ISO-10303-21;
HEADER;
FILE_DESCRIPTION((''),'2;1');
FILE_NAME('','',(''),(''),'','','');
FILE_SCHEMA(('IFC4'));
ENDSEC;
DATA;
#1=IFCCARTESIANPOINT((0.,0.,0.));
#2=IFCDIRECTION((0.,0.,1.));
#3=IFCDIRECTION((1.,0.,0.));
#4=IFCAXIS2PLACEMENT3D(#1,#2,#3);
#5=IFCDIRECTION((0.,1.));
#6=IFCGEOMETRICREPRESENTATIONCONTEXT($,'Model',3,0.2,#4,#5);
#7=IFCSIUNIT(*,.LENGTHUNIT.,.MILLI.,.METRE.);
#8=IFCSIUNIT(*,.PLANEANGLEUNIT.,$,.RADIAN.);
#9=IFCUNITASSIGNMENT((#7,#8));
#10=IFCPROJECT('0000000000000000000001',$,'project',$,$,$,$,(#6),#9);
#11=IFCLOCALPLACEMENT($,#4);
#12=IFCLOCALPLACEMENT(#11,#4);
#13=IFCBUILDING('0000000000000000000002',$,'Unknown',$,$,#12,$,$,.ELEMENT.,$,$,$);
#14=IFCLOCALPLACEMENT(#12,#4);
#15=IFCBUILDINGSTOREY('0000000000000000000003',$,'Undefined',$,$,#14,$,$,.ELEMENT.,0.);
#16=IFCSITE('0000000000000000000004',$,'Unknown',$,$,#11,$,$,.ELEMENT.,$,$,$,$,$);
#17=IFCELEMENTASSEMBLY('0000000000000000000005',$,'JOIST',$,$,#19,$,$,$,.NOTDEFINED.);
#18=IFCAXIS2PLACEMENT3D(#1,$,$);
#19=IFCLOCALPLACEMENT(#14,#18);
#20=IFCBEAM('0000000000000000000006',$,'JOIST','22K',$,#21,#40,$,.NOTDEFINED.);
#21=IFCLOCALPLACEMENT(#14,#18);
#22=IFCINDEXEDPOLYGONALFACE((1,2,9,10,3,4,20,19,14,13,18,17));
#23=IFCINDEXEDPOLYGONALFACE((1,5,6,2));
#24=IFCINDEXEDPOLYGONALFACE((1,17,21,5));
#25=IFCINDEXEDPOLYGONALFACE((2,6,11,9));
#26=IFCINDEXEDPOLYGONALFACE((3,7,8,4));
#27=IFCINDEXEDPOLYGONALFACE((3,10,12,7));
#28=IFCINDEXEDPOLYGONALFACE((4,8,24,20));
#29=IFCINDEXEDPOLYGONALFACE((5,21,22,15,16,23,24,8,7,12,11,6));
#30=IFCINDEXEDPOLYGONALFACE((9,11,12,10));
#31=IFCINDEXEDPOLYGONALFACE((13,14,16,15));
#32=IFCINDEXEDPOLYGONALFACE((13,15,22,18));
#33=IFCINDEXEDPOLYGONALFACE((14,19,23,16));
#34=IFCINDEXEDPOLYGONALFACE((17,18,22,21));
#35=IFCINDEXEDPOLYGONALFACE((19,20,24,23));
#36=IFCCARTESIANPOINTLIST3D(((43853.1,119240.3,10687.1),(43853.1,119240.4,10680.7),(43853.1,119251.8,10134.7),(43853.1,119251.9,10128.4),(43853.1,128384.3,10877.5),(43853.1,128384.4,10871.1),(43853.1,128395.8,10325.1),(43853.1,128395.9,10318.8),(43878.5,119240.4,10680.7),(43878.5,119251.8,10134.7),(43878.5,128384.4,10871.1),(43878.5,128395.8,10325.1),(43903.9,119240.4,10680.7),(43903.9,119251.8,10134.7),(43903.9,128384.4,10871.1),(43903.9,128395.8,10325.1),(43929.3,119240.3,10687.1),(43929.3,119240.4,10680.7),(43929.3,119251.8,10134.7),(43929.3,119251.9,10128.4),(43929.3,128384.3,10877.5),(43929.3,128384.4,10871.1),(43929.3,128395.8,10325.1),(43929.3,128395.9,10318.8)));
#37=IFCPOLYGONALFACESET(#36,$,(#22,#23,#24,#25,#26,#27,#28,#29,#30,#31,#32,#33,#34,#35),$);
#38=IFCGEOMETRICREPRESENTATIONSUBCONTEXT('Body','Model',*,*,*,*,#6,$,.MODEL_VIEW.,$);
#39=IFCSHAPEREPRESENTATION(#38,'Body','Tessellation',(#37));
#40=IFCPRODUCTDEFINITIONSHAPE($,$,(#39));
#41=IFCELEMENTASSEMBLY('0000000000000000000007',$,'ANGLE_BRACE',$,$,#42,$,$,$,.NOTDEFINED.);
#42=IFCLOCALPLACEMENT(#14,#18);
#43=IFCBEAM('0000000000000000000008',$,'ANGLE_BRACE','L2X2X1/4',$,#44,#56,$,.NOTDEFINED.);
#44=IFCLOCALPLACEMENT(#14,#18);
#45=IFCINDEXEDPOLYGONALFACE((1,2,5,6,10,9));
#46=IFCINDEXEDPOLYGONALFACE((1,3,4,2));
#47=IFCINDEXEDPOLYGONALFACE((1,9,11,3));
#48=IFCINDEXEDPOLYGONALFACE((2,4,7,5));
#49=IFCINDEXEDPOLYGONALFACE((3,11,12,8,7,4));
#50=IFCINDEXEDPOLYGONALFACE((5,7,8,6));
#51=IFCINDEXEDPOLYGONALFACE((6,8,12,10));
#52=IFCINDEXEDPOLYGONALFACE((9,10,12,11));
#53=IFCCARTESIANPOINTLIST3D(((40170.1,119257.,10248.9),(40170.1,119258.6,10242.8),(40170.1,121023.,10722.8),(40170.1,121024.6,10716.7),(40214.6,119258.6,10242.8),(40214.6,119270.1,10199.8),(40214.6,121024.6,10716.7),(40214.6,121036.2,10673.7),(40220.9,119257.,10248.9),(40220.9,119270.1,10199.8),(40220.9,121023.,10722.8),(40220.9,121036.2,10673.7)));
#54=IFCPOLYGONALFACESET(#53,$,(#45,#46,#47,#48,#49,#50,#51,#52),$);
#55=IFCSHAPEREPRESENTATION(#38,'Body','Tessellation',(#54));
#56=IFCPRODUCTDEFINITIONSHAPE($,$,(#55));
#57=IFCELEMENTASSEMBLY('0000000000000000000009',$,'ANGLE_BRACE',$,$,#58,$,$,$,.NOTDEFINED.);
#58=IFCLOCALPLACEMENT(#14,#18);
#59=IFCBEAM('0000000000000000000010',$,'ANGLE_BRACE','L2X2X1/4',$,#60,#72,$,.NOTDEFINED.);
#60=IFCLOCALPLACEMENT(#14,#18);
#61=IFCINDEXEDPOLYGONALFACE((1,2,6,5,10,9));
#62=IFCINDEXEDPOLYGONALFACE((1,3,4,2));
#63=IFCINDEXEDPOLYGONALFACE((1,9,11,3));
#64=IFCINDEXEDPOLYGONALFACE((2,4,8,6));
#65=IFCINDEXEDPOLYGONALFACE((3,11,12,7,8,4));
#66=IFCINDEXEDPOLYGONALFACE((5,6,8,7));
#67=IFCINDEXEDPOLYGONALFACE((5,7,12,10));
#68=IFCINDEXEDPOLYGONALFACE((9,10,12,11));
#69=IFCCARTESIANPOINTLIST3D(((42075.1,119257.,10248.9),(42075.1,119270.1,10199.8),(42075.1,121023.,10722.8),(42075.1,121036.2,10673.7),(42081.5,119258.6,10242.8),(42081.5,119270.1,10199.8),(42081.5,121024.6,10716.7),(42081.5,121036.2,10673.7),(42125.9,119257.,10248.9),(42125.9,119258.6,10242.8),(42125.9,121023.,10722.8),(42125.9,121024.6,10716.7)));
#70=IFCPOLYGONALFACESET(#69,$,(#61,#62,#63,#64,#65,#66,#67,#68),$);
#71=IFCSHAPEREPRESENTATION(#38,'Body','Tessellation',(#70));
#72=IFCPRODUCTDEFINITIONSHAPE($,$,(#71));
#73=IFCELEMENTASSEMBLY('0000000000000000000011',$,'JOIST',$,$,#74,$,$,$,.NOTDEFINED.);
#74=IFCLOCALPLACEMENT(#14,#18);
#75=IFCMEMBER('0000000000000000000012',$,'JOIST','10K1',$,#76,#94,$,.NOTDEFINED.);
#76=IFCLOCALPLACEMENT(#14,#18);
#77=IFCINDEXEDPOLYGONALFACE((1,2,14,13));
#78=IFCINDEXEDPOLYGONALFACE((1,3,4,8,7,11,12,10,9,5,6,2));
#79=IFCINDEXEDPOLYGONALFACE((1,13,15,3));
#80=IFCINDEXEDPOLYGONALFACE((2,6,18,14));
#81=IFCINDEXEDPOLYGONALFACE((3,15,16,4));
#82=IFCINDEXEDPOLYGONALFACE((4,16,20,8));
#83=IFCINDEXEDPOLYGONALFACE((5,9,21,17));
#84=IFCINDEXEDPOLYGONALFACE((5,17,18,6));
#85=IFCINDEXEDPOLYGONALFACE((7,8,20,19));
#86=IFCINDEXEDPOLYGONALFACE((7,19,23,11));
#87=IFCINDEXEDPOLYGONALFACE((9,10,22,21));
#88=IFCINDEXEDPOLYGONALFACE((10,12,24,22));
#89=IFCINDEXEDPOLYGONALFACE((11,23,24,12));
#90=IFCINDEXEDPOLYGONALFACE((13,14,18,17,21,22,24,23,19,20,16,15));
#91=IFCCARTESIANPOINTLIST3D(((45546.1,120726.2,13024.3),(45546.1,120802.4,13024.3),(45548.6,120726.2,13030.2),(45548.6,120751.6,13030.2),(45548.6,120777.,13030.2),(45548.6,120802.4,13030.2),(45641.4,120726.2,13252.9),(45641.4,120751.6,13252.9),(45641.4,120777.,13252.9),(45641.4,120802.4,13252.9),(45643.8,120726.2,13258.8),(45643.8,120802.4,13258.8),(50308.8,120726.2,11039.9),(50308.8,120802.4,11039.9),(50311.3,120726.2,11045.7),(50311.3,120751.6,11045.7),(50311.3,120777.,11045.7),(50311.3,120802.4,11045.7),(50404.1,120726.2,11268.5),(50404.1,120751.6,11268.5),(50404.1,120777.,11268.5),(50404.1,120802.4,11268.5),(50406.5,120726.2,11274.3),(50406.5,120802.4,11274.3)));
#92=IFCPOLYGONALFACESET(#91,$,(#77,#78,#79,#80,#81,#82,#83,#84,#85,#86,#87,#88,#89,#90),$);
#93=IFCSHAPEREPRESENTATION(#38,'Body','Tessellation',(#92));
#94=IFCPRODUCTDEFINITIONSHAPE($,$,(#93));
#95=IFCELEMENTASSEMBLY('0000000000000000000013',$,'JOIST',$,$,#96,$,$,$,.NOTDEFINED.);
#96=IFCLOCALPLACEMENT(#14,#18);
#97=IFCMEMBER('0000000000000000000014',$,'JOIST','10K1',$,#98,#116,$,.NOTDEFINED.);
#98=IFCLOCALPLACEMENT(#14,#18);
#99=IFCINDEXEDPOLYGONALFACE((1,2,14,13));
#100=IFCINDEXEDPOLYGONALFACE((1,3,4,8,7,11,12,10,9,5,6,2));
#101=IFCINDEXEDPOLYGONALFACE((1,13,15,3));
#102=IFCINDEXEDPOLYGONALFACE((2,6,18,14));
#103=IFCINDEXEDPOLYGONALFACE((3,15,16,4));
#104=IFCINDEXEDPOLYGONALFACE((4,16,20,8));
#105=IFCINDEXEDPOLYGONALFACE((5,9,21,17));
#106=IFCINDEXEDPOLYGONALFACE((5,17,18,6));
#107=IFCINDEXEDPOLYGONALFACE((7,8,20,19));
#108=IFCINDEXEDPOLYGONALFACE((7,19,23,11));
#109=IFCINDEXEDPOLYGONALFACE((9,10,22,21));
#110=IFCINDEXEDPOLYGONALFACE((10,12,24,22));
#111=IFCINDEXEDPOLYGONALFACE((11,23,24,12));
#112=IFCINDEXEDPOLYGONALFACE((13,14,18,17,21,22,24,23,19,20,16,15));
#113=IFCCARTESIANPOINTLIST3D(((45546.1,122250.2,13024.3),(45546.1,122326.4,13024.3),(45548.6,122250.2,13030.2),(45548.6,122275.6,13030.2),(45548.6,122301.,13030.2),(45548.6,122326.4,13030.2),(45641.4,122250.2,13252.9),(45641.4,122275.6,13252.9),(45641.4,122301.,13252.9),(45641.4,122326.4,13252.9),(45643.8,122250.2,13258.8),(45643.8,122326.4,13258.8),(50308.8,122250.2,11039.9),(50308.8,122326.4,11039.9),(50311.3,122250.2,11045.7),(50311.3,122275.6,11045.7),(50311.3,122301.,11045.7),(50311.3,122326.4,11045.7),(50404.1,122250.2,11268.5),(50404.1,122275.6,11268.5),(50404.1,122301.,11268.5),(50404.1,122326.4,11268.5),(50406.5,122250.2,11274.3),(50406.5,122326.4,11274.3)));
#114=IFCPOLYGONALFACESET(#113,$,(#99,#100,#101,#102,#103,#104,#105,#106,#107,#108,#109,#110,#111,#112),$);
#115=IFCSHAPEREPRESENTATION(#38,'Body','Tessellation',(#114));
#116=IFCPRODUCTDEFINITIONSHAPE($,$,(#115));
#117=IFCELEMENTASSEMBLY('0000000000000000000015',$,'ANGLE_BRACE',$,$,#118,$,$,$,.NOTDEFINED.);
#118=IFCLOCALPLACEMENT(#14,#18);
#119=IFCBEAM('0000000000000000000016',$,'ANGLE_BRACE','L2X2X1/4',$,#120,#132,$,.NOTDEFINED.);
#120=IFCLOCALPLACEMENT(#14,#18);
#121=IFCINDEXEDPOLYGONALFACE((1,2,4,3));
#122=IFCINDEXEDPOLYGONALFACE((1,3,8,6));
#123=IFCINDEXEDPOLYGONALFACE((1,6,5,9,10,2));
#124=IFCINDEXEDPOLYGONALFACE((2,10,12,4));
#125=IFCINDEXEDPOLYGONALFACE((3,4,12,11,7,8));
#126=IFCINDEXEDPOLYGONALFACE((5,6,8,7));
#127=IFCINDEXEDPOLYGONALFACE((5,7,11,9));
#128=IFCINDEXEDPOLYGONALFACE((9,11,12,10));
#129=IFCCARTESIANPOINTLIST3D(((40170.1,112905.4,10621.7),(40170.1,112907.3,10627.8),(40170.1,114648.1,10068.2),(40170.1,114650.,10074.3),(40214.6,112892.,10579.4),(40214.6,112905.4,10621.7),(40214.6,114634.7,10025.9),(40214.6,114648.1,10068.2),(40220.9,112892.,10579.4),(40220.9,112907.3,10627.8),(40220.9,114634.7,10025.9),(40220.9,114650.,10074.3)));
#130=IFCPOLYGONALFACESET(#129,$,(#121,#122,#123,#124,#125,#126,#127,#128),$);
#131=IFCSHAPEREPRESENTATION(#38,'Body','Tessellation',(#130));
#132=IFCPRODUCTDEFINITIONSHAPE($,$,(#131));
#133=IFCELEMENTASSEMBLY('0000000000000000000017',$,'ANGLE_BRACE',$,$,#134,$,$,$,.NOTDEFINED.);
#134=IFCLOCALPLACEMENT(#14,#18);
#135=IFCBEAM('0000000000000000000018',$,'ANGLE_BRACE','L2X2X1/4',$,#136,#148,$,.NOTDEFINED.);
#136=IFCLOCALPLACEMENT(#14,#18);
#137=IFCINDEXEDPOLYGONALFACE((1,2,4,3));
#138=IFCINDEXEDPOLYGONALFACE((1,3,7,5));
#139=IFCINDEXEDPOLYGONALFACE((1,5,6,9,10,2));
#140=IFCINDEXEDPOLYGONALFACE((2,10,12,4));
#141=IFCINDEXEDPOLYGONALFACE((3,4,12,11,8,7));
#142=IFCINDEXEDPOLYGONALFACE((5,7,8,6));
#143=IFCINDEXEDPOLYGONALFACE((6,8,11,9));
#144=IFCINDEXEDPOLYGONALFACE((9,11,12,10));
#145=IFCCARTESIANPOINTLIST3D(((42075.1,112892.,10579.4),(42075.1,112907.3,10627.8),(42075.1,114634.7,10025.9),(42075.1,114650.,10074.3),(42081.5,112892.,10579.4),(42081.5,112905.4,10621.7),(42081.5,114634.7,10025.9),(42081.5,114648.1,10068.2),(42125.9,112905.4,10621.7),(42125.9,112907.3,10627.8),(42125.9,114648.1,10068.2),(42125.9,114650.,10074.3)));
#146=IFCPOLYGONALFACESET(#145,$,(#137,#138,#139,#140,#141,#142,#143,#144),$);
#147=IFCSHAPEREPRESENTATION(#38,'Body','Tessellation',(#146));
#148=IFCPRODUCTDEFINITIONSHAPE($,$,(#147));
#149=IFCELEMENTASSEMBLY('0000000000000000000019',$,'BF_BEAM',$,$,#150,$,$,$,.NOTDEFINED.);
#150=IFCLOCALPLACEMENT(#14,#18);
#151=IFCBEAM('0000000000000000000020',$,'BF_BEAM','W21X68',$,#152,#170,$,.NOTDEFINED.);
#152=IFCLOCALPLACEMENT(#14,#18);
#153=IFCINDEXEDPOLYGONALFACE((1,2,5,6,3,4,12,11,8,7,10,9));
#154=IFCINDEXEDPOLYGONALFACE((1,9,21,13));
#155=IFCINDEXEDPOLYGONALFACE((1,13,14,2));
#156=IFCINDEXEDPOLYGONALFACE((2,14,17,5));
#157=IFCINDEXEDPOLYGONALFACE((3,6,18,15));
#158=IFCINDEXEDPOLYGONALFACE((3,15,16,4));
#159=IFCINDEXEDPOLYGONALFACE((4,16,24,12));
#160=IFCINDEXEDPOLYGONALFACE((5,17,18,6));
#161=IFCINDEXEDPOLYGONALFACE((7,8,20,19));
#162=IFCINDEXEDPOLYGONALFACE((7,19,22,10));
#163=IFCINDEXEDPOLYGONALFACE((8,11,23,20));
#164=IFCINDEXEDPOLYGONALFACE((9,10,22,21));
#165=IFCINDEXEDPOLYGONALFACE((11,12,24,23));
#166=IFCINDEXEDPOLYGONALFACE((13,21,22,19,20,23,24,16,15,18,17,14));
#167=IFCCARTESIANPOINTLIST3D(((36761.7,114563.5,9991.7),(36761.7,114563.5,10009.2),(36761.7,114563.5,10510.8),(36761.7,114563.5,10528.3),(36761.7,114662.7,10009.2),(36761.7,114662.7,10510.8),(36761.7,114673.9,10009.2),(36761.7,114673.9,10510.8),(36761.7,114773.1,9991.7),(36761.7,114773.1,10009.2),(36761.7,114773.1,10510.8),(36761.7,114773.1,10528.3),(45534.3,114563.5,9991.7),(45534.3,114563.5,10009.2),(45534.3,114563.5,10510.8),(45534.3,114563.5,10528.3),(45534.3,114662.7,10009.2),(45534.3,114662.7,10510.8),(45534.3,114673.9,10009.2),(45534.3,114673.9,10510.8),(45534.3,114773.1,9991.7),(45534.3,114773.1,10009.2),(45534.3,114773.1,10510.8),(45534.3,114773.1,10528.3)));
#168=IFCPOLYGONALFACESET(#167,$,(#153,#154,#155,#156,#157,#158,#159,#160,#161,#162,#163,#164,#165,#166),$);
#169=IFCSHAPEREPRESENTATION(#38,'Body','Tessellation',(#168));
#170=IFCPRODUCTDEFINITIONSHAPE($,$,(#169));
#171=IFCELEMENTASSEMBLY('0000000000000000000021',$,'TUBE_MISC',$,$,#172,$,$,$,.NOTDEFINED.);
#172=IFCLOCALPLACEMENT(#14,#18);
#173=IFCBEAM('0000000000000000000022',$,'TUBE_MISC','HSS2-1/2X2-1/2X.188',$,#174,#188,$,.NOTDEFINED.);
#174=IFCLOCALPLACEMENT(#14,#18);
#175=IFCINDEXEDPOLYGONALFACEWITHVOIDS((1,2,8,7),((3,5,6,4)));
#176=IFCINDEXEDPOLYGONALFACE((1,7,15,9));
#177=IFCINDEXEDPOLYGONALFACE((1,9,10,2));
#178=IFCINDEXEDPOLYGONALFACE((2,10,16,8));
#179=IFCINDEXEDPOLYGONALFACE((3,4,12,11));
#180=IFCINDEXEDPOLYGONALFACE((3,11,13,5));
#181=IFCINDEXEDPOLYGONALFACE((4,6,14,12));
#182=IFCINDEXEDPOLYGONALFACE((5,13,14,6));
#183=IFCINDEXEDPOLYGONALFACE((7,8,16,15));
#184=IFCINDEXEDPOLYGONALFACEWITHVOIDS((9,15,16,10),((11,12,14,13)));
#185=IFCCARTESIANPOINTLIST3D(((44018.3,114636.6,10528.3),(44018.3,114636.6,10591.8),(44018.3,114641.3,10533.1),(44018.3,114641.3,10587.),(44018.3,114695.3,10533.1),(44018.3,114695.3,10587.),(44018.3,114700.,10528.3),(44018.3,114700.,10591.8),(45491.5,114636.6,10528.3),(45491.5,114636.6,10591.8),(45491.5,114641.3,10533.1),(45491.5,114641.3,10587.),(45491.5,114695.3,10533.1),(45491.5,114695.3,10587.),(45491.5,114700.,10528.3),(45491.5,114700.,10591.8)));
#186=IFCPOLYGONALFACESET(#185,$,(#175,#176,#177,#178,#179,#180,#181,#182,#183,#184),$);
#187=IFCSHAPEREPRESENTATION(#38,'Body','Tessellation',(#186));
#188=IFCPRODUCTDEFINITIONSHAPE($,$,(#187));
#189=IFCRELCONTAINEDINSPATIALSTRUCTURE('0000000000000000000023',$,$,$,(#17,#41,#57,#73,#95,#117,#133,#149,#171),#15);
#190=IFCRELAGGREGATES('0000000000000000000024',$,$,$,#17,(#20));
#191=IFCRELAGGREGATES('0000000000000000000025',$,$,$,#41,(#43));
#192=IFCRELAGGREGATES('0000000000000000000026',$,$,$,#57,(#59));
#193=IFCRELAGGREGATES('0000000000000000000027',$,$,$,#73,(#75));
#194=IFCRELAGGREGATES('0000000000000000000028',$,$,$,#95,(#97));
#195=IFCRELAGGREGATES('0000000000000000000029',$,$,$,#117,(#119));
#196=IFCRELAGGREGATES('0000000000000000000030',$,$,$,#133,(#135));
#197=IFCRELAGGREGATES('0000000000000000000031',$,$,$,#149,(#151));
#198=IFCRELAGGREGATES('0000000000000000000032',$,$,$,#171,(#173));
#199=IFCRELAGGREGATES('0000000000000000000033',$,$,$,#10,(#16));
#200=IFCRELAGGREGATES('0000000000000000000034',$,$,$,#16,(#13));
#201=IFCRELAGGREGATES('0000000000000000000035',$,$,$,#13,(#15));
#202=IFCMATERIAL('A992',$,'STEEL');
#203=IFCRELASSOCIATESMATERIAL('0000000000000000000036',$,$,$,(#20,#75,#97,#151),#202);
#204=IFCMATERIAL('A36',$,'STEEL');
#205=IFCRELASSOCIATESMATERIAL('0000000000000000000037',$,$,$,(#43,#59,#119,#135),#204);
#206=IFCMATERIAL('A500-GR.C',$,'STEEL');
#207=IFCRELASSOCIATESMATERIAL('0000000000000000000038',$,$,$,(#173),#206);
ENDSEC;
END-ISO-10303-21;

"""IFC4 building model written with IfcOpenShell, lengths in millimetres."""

from ifc_helpers import new_model, si_unit, direction, frame, origin_with_axes, place, context, subcontext, project, spatial, line, indexed_curve, outline, extrude, material, element, aggregate, save


model = new_model("IFC4")

# Units and contexts
model_context = context("Model", 3, precision=0.2, world=origin_with_axes(), true_north=direction((0.0, 1.0)))
body_context = subcontext(model_context, "Body", "Model", "MODEL_VIEW")
ifc_project = project(units=[si_unit("LENGTHUNIT", "METRE", prefix="MILLI"), si_unit("PLANEANGLEUNIT", "RADIAN")], contexts=[model_context])

# Site, building, storey
site_placement = place(None, origin_with_axes())
site = spatial("IfcSite", under=ifc_project, at=site_placement, Name="Unknown", CompositionType="ELEMENT")
building_placement = place(site_placement, origin_with_axes())
building = spatial("IfcBuilding", under=site, at=building_placement, Name="Unknown", CompositionType="ELEMENT")
storey_placement = place(building_placement, origin_with_axes())
storey = spatial("IfcBuildingStorey", under=building, at=storey_placement, Name="Undefined", CompositionType="ELEMENT", Elevation=0.0)

# Element assemblies, beams
ifc_material_1 = material(Name="A992", Category="STEEL")
assembly_1_placement = place(storey_placement, frame((43891.2, 119246.1, 10407.7), z_axis=(1.0, 0.0, 0.0), x_axis=(0.0, 0.999783, 0.020819)))
assembly_1 = element("IfcElementAssembly", 1, at=assembly_1_placement, inside=storey, Name="JOIST", PredefinedType="NOTDEFINED")
beam_1_placement = place(assembly_1_placement, origin_with_axes())
beam_1 = element("IfcBeam", 2, at=beam_1_placement, material=ifc_material_1, Name="JOIST", Description="22K", PredefinedType="NOTDEFINED", context=body_context, shape_type="SolidModel", body=[
    extrude(outline(indexed_curve([(-38.1, -279.4), (38.1, -279.4), (38.1, -273.0), (12.7, -273.0), (12.7, 273.0), (38.1, 273.0), (38.1, 279.4), (-38.1, 279.4), (-38.1, 273.0), (-12.7, 273.0), (-12.7, -273.0), (-38.1, -273.0)], segments=[line(1, 2, 3, 4, 5, 6, 7, 8, 9, 10, 11, 12, 1)])), frame((0.0, 0.0, 0.0), z_axis=(-1.0, 0.0, 0.0), x_axis=(0.0, 0.0, 1.0)), (0.0, 0.0, -1.0), 9146.0),
])
aggregate(assembly_1, [beam_1])
assembly_2_placement = place(storey_placement, frame((40195.5, 119263.6, 10224.4), z_axis=(-1.0, 0.0, 0.0), x_axis=(0.0, 0.965831, 0.259174)))
assembly_2 = element("IfcElementAssembly", 3, at=assembly_2_placement, inside=storey, Name="ANGLE_BRACE", PredefinedType="NOTDEFINED")
ifc_material_2 = material(Name="A36", Category="STEEL")
beam_2_placement = place(assembly_2_placement, origin_with_axes())
beam_2 = element("IfcBeam", 4, at=beam_2_placement, material=ifc_material_2, Name="ANGLE_BRACE", Description="L2X2X1/4", PredefinedType="NOTDEFINED", context=body_context, shape_type="SolidModel", body=[
    extrude(outline(indexed_curve([(-25.4, -25.4), (25.4, -25.4), (25.4, -19.1), (-19.1, -19.1), (-19.1, 25.4), (-25.4, 25.4)], segments=[line(1, 2, 3, 4, 5, 6, 1)])), frame((0.0, 0.0, 0.0), z_axis=(-1.0, 0.0, 0.0), x_axis=(0.0, 0.0, 1.0)), (0.0, 0.0, -1.0), 1828.5),
])
aggregate(assembly_2, [beam_2])
assembly_3_placement = place(storey_placement, frame((42100.5, 119263.6, 10224.4), z_axis=(0.0, 0.259174, -0.965831), x_axis=(0.0, 0.965831, 0.259174)))
assembly_3 = element("IfcElementAssembly", 5, at=assembly_3_placement, inside=storey, Name="ANGLE_BRACE", PredefinedType="NOTDEFINED")
beam_3_placement = place(assembly_3_placement, origin_with_axes())
beam_3 = element("IfcBeam", 6, at=beam_3_placement, material=ifc_material_2, Name="ANGLE_BRACE", Description="L2X2X1/4", PredefinedType="NOTDEFINED", context=body_context, shape_type="SolidModel", body=[
    extrude(outline(indexed_curve([(-25.4, -25.4), (25.4, -25.4), (25.4, -19.1), (-19.1, -19.1), (-19.1, 25.4), (-25.4, 25.4)], segments=[line(1, 2, 3, 4, 5, 6, 1)])), frame((0.0, 0.0, 0.0), z_axis=(-1.0, 0.0, 0.0), x_axis=(0.0, 0.0, 1.0)), (0.0, 0.0, -1.0), 1828.5),
])
aggregate(assembly_3, [beam_3])

# Element assemblies, members
assembly_4_placement = place(storey_placement, frame((45595.0, 120764.3, 13141.6), z_axis=(0.0, -1.0, 0.0), x_axis=(0.923077, 0.000001, -0.384615)))
assembly_4 = element("IfcElementAssembly", 7, at=assembly_4_placement, inside=storey, Name="JOIST", PredefinedType="NOTDEFINED")
member_1_placement = place(assembly_4_placement, origin_with_axes())
member_1 = element("IfcMember", 8, at=member_1_placement, material=ifc_material_1, Name="JOIST", Description="10K1", PredefinedType="NOTDEFINED", context=body_context, shape_type="SolidModel", body=[
    extrude(outline(indexed_curve([(-38.1, -127.0), (38.1, -127.0), (38.1, -120.7), (12.7, -120.7), (12.7, 120.7), (38.1, 120.7), (38.1, 127.0), (-38.1, 127.0), (-38.1, 120.7), (-12.7, 120.7), (-12.7, -120.7), (-38.1, -120.7)], segments=[line(1, 2, 3, 4, 5, 6, 7, 8, 9, 10, 11, 12, 1)])), frame((0.0, 0.0, 0.0), z_axis=(-1.0, 0.0, 0.0), x_axis=(0.0, 0.0, 1.0)), (0.0, 0.0, -1.0), 5159.6),
])
aggregate(assembly_4, [member_1])
assembly_5_placement = place(storey_placement, frame((45595.0, 122288.3, 13141.6), z_axis=(0.0, -1.0, 0.0), x_axis=(0.923077, 0.000001, -0.384615)))
assembly_5 = element("IfcElementAssembly", 9, at=assembly_5_placement, inside=storey, Name="JOIST", PredefinedType="NOTDEFINED")
member_2_placement = place(assembly_5_placement, origin_with_axes())
member_2 = element("IfcMember", 10, at=member_2_placement, material=ifc_material_1, Name="JOIST", Description="10K1", PredefinedType="NOTDEFINED", context=body_context, shape_type="SolidModel", body=[
    extrude(outline(indexed_curve([(-38.1, -127.0), (38.1, -127.0), (38.1, -120.7), (12.7, -120.7), (12.7, 120.7), (38.1, 120.7), (38.1, 127.0), (-38.1, 127.0), (-38.1, 120.7), (-12.7, 120.7), (-12.7, -120.7), (-38.1, -120.7)], segments=[line(1, 2, 3, 4, 5, 6, 7, 8, 9, 10, 11, 12, 1)])), frame((0.0, 0.0, 0.0), z_axis=(-1.0, 0.0, 0.0), x_axis=(0.0, 0.0, 1.0)), (0.0, 0.0, -1.0), 5159.6),
])
aggregate(assembly_5, [member_2])

# Element assemblies, beams
assembly_6_placement = place(storey_placement, frame((40195.5, 114642.4, 10050.1), z_axis=(0.0, -0.30272, -0.953079), x_axis=(0.0, -0.953079, 0.30272)))
assembly_6 = element("IfcElementAssembly", 11, at=assembly_6_placement, inside=storey, Name="ANGLE_BRACE", PredefinedType="NOTDEFINED")
beam_4_placement = place(assembly_6_placement, origin_with_axes())
beam_4 = element("IfcBeam", 12, at=beam_4_placement, material=ifc_material_2, Name="ANGLE_BRACE", Description="L2X2X1/4", PredefinedType="NOTDEFINED", context=body_context, shape_type="SolidModel", body=[
    extrude(outline(indexed_curve([(-25.4, -25.4), (25.4, -25.4), (25.4, -19.1), (-19.1, -19.1), (-19.1, 25.4), (-25.4, 25.4)], segments=[line(1, 2, 3, 4, 5, 6, 1)])), frame((0.0, 0.0, 0.0), z_axis=(-1.0, 0.0, 0.0), x_axis=(0.0, 0.0, 1.0)), (0.0, 0.0, -1.0), 1828.5),
])
aggregate(assembly_6, [beam_4])
assembly_7_placement = place(storey_placement, frame((42100.5, 114642.4, 10050.1), z_axis=(1.0, 0.0, 0.0), x_axis=(0.0, -0.953079, 0.30272)))
assembly_7 = element("IfcElementAssembly", 13, at=assembly_7_placement, inside=storey, Name="ANGLE_BRACE", PredefinedType="NOTDEFINED")
beam_5_placement = place(assembly_7_placement, origin_with_axes())
beam_5 = element("IfcBeam", 14, at=beam_5_placement, material=ifc_material_2, Name="ANGLE_BRACE", Description="L2X2X1/4", PredefinedType="NOTDEFINED", context=body_context, shape_type="SolidModel", body=[
    extrude(outline(indexed_curve([(-25.4, -25.4), (25.4, -25.4), (25.4, -19.1), (-19.1, -19.1), (-19.1, 25.4), (-25.4, 25.4)], segments=[line(1, 2, 3, 4, 5, 6, 1)])), frame((0.0, 0.0, 0.0), z_axis=(-1.0, 0.0, 0.0), x_axis=(0.0, 0.0, 1.0)), (0.0, 0.0, -1.0), 1828.5),
])
aggregate(assembly_7, [beam_5])
assembly_8_placement = place(storey_placement, frame((36761.7, 114668.3, 10260.0), z_axis=(0.0, -1.0, 0.0), x_axis=(1.0, 0.0, 0.0)))
assembly_8 = element("IfcElementAssembly", 15, at=assembly_8_placement, inside=storey, Name="BF_BEAM", PredefinedType="NOTDEFINED")
beam_6_placement = place(assembly_8_placement, origin_with_axes())
beam_6 = element("IfcBeam", 16, at=beam_6_placement, material=ifc_material_1, Name="BF_BEAM", Description="W21X68", PredefinedType="NOTDEFINED", context=body_context, shape_type="SolidModel", body=[
    extrude(outline(indexed_curve([(-104.8, -268.3), (104.8, -268.3), (104.8, -250.8), (5.6, -250.8), (5.6, 250.8), (104.8, 250.8), (104.8, 268.3), (-104.8, 268.3), (-104.8, 250.8), (-5.6, 250.8), (-5.6, -250.8), (-104.8, -250.8)], segments=[line(1, 2, 3, 4, 5, 6, 7, 8, 9, 10, 11, 12, 1)])), frame((0.0, 0.0, 0.0), z_axis=(-1.0, 0.0, 0.0), x_axis=(0.0, 0.0, 1.0)), (0.0, 0.0, -1.0), 8772.5),
])
aggregate(assembly_8, [beam_6])
assembly_9_placement = place(storey_placement, frame((44018.3, 114668.3, 10560.0), z_axis=(0.0, -1.0, 0.0), x_axis=(1.0, 0.0, 0.0)))
assembly_9 = element("IfcElementAssembly", 17, at=assembly_9_placement, inside=storey, Name="TUBE_MISC", PredefinedType="NOTDEFINED")
ifc_material_3 = material(Name="A500-GR.C", Category="STEEL")
beam_7_placement = place(assembly_9_placement, origin_with_axes())
beam_7 = element("IfcBeam", 18, at=beam_7_placement, material=ifc_material_3, Name="TUBE_MISC", Description="HSS2-1/2X2-1/2X.188", PredefinedType="NOTDEFINED", context=body_context, shape_type="SolidModel", body=[
    extrude(outline(indexed_curve([(-31.8, -31.8), (31.8, -31.8), (31.8, 31.8), (-31.8, 31.8)], segments=[line(1, 2, 3, 4, 1)]), holes=[indexed_curve([(-27.0, -27.0), (-27.0, 27.0), (27.0, 27.0), (27.0, -27.0)], segments=[line(1, 2, 3, 4, 1)])]), frame((0.0, 0.0, 0.0), z_axis=(-1.0, 0.0, 0.0), x_axis=(0.0, 0.0, 1.0)), (0.0, 0.0, -1.0), 1473.2),
])
aggregate(assembly_9, [beam_7])

save(model, "model.ifc")
